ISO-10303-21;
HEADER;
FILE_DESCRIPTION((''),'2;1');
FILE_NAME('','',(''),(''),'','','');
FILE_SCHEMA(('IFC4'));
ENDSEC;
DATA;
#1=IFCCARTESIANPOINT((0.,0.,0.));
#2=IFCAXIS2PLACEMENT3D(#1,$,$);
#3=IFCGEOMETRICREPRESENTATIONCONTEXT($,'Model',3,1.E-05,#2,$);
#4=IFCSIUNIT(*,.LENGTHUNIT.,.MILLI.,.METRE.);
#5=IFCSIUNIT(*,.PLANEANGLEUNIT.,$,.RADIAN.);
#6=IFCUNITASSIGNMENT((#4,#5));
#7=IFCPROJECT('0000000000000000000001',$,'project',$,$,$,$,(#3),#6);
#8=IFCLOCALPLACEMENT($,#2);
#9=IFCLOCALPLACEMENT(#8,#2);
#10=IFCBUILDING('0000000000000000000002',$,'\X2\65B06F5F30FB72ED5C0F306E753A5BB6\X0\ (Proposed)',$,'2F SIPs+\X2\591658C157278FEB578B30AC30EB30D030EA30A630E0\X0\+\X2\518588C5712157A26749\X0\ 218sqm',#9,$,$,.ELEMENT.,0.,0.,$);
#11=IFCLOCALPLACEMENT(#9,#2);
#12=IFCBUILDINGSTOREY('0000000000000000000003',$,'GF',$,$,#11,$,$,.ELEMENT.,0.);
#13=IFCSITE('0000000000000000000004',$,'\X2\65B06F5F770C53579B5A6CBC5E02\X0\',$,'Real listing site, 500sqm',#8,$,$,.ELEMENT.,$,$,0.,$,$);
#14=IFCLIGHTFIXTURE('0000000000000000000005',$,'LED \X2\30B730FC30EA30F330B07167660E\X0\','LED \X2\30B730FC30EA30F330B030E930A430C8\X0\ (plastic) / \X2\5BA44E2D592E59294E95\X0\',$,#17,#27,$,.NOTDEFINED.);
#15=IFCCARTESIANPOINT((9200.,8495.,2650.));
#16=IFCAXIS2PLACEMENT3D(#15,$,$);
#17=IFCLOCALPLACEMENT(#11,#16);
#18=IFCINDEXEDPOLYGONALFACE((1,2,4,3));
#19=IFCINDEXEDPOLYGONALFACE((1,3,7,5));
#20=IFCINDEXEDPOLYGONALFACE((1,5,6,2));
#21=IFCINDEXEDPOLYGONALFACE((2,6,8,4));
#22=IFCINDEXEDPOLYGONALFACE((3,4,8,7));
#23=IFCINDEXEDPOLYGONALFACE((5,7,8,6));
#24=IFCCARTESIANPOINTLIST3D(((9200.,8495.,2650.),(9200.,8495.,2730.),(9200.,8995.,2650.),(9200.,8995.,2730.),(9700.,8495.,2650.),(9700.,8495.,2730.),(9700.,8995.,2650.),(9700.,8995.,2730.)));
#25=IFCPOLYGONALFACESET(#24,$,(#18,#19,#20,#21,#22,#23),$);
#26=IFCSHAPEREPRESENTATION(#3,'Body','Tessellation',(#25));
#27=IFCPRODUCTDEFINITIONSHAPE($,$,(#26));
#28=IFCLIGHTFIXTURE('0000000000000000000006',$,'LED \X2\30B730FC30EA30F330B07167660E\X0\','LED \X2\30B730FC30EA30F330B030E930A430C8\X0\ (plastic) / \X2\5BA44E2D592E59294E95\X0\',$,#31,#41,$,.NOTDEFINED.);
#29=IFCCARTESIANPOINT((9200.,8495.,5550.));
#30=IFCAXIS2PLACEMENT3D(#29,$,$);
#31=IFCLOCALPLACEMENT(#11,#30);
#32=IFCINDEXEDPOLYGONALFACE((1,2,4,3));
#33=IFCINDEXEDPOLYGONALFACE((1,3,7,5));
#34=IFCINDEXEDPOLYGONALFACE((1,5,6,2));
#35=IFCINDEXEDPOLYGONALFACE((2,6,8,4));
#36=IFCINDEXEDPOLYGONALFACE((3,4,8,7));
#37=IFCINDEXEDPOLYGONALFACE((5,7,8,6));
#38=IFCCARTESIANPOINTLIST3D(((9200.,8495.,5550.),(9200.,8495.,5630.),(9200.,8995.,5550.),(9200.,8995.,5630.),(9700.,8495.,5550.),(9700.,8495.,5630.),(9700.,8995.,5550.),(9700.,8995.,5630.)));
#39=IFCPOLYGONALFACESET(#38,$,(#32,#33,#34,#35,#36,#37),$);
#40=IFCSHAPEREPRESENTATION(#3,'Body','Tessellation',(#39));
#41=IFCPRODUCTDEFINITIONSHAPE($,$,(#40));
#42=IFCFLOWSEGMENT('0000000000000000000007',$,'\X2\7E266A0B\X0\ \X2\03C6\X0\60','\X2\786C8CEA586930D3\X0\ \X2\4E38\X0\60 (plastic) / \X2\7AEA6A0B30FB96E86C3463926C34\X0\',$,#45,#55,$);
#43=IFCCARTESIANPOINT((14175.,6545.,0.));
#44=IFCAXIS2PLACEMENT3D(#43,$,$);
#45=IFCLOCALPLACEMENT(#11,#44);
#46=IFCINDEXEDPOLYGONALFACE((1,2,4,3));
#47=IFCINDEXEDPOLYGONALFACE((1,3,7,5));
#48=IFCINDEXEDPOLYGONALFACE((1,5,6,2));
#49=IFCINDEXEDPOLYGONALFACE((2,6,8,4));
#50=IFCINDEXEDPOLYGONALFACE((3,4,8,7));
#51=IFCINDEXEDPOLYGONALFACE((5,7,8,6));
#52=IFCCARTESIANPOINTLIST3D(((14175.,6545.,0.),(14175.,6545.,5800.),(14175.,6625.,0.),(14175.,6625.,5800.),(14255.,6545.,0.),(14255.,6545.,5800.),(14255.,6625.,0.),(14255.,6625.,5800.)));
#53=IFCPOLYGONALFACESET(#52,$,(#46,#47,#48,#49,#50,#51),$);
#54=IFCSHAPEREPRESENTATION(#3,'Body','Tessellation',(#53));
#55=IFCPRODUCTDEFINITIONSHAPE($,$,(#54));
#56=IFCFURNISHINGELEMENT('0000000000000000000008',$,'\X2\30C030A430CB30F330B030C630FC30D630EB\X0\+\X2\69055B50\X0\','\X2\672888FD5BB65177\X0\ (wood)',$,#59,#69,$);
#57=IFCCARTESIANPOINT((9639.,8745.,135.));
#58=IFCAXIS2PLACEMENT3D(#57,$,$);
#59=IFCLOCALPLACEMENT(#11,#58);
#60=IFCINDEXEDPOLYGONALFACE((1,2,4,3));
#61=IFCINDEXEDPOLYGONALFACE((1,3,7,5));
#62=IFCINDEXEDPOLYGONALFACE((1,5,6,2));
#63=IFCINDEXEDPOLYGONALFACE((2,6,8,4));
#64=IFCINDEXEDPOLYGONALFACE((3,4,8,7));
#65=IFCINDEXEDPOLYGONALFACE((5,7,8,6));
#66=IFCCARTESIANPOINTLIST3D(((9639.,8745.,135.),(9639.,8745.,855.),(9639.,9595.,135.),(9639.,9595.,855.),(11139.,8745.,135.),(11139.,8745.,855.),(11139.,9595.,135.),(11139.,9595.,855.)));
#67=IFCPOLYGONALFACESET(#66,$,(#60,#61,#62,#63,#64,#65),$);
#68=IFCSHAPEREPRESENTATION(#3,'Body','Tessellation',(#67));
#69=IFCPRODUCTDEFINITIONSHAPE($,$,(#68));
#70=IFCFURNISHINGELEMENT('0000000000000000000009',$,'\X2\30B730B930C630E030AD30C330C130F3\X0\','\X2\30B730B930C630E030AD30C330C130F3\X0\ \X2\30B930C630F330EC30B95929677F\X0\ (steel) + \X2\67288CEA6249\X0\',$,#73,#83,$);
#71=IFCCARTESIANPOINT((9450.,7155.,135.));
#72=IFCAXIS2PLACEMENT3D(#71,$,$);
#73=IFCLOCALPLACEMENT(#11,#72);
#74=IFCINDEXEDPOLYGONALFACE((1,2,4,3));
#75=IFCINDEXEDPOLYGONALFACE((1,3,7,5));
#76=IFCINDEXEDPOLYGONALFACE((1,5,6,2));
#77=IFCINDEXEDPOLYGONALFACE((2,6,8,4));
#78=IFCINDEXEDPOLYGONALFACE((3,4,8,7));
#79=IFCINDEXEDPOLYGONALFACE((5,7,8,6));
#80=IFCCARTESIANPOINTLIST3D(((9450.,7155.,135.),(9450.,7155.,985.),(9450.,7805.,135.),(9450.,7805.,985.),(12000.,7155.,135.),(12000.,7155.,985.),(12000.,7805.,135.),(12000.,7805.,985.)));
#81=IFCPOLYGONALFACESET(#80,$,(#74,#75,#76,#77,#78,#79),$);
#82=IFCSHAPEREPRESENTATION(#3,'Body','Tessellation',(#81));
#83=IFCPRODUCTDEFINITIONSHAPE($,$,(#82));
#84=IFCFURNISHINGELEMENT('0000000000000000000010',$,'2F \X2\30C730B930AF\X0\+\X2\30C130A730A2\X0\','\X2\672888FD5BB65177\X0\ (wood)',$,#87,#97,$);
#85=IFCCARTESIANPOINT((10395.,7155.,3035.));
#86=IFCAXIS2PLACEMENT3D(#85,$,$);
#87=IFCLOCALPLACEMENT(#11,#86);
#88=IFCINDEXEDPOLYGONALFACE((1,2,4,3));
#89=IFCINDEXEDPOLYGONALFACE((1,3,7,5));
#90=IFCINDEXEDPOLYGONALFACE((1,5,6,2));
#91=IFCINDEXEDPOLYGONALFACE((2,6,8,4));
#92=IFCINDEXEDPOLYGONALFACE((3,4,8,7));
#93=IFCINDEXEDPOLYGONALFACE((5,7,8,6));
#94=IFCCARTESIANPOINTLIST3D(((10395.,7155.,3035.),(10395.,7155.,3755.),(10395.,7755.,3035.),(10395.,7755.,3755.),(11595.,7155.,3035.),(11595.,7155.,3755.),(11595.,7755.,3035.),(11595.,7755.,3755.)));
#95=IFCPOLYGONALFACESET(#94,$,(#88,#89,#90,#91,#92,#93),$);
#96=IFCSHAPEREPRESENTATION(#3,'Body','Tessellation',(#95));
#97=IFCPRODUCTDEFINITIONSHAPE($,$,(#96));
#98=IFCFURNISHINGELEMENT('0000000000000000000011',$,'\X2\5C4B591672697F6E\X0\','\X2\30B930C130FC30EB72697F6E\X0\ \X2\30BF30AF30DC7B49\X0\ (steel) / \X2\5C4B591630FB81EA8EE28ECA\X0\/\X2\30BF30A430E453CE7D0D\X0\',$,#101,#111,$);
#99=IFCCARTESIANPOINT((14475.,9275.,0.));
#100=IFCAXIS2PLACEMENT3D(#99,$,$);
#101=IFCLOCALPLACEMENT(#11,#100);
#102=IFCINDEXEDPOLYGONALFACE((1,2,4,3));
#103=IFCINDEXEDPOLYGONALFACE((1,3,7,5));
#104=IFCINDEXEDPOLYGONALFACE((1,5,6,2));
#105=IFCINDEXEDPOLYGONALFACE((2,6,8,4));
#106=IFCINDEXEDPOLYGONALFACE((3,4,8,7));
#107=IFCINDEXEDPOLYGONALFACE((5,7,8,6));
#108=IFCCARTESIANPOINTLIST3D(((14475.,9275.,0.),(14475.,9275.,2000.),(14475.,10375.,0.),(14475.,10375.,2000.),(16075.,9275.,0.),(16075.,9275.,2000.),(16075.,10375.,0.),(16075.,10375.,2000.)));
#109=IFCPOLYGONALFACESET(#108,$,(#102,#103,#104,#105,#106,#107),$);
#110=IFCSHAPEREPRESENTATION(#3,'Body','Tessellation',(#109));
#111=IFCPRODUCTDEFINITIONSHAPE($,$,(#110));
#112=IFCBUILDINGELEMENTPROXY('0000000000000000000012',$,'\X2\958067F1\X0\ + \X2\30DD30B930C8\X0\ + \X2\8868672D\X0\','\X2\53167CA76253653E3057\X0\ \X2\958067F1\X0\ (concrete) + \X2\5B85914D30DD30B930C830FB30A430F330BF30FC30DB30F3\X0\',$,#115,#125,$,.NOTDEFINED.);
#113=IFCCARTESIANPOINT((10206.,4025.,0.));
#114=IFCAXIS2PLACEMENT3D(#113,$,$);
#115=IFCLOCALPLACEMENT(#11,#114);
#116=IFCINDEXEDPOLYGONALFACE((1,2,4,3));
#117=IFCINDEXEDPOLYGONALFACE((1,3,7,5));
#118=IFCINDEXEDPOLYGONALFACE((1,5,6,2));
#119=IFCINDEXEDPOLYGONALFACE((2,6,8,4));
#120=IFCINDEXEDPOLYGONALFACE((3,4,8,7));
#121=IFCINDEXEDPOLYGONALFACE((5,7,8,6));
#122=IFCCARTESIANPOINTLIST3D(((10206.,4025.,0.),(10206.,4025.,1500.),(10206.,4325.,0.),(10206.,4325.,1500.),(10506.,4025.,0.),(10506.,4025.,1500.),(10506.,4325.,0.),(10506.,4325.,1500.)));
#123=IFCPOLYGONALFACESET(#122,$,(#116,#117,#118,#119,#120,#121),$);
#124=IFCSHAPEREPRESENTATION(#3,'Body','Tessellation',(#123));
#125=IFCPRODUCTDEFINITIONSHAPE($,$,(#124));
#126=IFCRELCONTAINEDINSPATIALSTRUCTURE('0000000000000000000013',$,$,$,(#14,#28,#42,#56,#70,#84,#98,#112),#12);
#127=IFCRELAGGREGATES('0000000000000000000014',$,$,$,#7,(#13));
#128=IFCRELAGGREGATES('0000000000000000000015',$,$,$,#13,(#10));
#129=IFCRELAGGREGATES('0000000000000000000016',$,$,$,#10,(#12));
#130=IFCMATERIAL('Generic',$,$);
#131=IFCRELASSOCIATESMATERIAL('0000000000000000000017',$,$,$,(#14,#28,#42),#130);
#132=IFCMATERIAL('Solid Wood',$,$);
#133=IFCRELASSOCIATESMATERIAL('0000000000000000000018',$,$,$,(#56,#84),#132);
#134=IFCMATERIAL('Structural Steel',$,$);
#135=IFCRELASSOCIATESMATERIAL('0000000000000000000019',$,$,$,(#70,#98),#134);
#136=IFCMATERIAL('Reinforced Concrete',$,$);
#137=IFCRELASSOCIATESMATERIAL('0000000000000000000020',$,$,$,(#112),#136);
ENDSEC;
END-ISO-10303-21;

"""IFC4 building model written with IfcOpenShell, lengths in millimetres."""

from ifc_helpers import new_model, si_unit, frame, frame_2d, origin, place, context, project, spatial, rectangle, extrude, material, element, save


model = new_model("IFC4")

# Units and contexts
model_context = context("Model", 3, precision=1e-05, world=origin())
ifc_project = project(units=[si_unit("LENGTHUNIT", "METRE", prefix="MILLI"), si_unit("PLANEANGLEUNIT", "RADIAN")], contexts=[model_context])

# Site, building, storey
site_placement = place(None, origin())
site = spatial("IfcSite", under=ifc_project, at=site_placement, Name="新潟県南魚沼市", ObjectType="Real listing site, 500sqm", CompositionType="ELEMENT", RefElevation=0.0)
building_placement = place(site_placement, origin())
building = spatial("IfcBuilding", under=site, at=building_placement, Name="新潟・狭小の町家 (Proposed)", ObjectType="2F SIPs+外壁圧迫型ガルバリウム+内装無垢杉 218sqm", CompositionType="ELEMENT", ElevationOfRefHeight=0.0, ElevationOfTerrain=0.0)
storey_placement = place(building_placement, origin())
storey = spatial("IfcBuildingStorey", under=building, at=storey_placement, Name="GF", CompositionType="ELEMENT", Elevation=0.0)

# Shared definitions
ifc_material_1 = material(Name="Solid Wood")

# Shared definitions
ifc_material_2 = material(Name="Reinforced Concrete")

# Shared definitions
ifc_material_3 = material(Name="Structural Steel")

# Shared definitions
ifc_material_4 = material(Name="Generic")

# Light fixtures
light_fixture_1_placement = place(storey_placement, frame((9200.0, 8495.0, 2650.0)))
element("IfcLightFixture", 1, at=light_fixture_1_placement, inside=storey, material=ifc_material_4, Name="LED シーリング照明", Description="LED シーリングライト (plastic) / 室中央天井", PredefinedType="NOTDEFINED", context=model_context, shape_type="SweptSolid", body=[
    extrude(rectangle(XDim=500.0, YDim=500.0, at=frame_2d((250.0, 250.0))), frame((9200.0, 8495.0, 2650.0)), (0.0, 0.0, 1.0), 80.0),
])
light_fixture_2_placement = place(storey_placement, frame((9200.0, 8495.0, 5550.0)))
element("IfcLightFixture", 2, at=light_fixture_2_placement, inside=storey, material=ifc_material_4, Name="LED シーリング照明", Description="LED シーリングライト (plastic) / 室中央天井", PredefinedType="NOTDEFINED", context=model_context, shape_type="SweptSolid", body=[
    extrude(rectangle(XDim=500.0, YDim=500.0, at=frame_2d((250.0, 250.0))), frame((9200.0, 8495.0, 5550.0)), (0.0, 0.0, 1.0), 80.0),
])

# Flow segment
flow_segment_placement = place(storey_placement, frame((14175.0, 6545.0, 0.0)))
element("IfcFlowSegment", 3, at=flow_segment_placement, inside=storey, material=ifc_material_4, Name="縦樋 φ60", Description="硬質塩ビ 丸60 (plastic) / 竪樋・雨水排水", context=model_context, shape_type="SweptSolid", body=[
    extrude(rectangle(XDim=80.0, YDim=80.0, at=frame_2d((40.0, 40.0))), frame((14175.0, 6545.0, 0.0)), (0.0, 0.0, 1.0), 5800.0),
])

# Furnishing elements
furnishing_1_placement = place(storey_placement, frame((9639.0, 8745.0, 135.0)))
element("IfcFurnishingElement", 4, at=furnishing_1_placement, inside=storey, material=ifc_material_1, Name="ダイニングテーブル+椅子", Description="木製家具 (wood)", context=model_context, shape_type="SweptSolid", body=[
    extrude(rectangle(XDim=1500.0, YDim=850.0, at=frame_2d((750.0, 425.0))), frame((9639.0, 8745.0, 135.0)), (0.0, 0.0, 1.0), 720.0),
])
furnishing_2_placement = place(storey_placement, frame((9450.0, 7155.0, 135.0)))
element("IfcFurnishingElement", 5, at=furnishing_2_placement, inside=storey, material=ifc_material_3, Name="システムキッチン", Description="システムキッチン ステンレス天板 (steel) + 木質扉", context=model_context, shape_type="SweptSolid", body=[
    extrude(rectangle(XDim=2550.0, YDim=650.0, at=frame_2d((1275.0, 325.0))), frame((9450.0, 7155.0, 135.0)), (0.0, 0.0, 1.0), 850.0),
])
furnishing_3_placement = place(storey_placement, frame((10395.0, 7155.0, 3035.0)))
element("IfcFurnishingElement", 6, at=furnishing_3_placement, inside=storey, material=ifc_material_1, Name="2F デスク+チェア", Description="木製家具 (wood)", context=model_context, shape_type="SweptSolid", body=[
    extrude(rectangle(XDim=1200.0, YDim=600.0, at=frame_2d((600.0, 300.0))), frame((10395.0, 7155.0, 3035.0)), (0.0, 0.0, 1.0), 720.0),
])
furnishing_4_placement = place(storey_placement, frame((14475.0, 9275.0, 0.0)))
element("IfcFurnishingElement", 7, at=furnishing_4_placement, inside=storey, material=ifc_material_3, Name="屋外物置", Description="スチール物置 タクボ等 (steel) / 屋外・自転車/タイヤ収納", context=model_context, shape_type="SweptSolid", body=[
    extrude(rectangle(XDim=1600.0, YDim=1100.0, at=frame_2d((800.0, 550.0))), frame((14475.0, 9275.0, 0.0)), (0.0, 0.0, 1.0), 2000.0),
])

# Building element proxy
proxy_placement = place(storey_placement, frame((10206.0, 4025.0, 0.0)))
element("IfcBuildingElementProxy", 8, at=proxy_placement, inside=storey, material=ifc_material_2, Name="門柱 + ポスト + 表札", Description="化粧打放し 門柱 (concrete) + 宅配ポスト・インターホン", PredefinedType="NOTDEFINED", context=model_context, shape_type="SweptSolid", body=[
    extrude(rectangle(XDim=300.0, YDim=300.0, at=frame_2d((150.0, 150.0))), frame((10206.0, 4025.0, 0.0)), (0.0, 0.0, 1.0), 1500.0),
])

save(model, "model.ifc")
